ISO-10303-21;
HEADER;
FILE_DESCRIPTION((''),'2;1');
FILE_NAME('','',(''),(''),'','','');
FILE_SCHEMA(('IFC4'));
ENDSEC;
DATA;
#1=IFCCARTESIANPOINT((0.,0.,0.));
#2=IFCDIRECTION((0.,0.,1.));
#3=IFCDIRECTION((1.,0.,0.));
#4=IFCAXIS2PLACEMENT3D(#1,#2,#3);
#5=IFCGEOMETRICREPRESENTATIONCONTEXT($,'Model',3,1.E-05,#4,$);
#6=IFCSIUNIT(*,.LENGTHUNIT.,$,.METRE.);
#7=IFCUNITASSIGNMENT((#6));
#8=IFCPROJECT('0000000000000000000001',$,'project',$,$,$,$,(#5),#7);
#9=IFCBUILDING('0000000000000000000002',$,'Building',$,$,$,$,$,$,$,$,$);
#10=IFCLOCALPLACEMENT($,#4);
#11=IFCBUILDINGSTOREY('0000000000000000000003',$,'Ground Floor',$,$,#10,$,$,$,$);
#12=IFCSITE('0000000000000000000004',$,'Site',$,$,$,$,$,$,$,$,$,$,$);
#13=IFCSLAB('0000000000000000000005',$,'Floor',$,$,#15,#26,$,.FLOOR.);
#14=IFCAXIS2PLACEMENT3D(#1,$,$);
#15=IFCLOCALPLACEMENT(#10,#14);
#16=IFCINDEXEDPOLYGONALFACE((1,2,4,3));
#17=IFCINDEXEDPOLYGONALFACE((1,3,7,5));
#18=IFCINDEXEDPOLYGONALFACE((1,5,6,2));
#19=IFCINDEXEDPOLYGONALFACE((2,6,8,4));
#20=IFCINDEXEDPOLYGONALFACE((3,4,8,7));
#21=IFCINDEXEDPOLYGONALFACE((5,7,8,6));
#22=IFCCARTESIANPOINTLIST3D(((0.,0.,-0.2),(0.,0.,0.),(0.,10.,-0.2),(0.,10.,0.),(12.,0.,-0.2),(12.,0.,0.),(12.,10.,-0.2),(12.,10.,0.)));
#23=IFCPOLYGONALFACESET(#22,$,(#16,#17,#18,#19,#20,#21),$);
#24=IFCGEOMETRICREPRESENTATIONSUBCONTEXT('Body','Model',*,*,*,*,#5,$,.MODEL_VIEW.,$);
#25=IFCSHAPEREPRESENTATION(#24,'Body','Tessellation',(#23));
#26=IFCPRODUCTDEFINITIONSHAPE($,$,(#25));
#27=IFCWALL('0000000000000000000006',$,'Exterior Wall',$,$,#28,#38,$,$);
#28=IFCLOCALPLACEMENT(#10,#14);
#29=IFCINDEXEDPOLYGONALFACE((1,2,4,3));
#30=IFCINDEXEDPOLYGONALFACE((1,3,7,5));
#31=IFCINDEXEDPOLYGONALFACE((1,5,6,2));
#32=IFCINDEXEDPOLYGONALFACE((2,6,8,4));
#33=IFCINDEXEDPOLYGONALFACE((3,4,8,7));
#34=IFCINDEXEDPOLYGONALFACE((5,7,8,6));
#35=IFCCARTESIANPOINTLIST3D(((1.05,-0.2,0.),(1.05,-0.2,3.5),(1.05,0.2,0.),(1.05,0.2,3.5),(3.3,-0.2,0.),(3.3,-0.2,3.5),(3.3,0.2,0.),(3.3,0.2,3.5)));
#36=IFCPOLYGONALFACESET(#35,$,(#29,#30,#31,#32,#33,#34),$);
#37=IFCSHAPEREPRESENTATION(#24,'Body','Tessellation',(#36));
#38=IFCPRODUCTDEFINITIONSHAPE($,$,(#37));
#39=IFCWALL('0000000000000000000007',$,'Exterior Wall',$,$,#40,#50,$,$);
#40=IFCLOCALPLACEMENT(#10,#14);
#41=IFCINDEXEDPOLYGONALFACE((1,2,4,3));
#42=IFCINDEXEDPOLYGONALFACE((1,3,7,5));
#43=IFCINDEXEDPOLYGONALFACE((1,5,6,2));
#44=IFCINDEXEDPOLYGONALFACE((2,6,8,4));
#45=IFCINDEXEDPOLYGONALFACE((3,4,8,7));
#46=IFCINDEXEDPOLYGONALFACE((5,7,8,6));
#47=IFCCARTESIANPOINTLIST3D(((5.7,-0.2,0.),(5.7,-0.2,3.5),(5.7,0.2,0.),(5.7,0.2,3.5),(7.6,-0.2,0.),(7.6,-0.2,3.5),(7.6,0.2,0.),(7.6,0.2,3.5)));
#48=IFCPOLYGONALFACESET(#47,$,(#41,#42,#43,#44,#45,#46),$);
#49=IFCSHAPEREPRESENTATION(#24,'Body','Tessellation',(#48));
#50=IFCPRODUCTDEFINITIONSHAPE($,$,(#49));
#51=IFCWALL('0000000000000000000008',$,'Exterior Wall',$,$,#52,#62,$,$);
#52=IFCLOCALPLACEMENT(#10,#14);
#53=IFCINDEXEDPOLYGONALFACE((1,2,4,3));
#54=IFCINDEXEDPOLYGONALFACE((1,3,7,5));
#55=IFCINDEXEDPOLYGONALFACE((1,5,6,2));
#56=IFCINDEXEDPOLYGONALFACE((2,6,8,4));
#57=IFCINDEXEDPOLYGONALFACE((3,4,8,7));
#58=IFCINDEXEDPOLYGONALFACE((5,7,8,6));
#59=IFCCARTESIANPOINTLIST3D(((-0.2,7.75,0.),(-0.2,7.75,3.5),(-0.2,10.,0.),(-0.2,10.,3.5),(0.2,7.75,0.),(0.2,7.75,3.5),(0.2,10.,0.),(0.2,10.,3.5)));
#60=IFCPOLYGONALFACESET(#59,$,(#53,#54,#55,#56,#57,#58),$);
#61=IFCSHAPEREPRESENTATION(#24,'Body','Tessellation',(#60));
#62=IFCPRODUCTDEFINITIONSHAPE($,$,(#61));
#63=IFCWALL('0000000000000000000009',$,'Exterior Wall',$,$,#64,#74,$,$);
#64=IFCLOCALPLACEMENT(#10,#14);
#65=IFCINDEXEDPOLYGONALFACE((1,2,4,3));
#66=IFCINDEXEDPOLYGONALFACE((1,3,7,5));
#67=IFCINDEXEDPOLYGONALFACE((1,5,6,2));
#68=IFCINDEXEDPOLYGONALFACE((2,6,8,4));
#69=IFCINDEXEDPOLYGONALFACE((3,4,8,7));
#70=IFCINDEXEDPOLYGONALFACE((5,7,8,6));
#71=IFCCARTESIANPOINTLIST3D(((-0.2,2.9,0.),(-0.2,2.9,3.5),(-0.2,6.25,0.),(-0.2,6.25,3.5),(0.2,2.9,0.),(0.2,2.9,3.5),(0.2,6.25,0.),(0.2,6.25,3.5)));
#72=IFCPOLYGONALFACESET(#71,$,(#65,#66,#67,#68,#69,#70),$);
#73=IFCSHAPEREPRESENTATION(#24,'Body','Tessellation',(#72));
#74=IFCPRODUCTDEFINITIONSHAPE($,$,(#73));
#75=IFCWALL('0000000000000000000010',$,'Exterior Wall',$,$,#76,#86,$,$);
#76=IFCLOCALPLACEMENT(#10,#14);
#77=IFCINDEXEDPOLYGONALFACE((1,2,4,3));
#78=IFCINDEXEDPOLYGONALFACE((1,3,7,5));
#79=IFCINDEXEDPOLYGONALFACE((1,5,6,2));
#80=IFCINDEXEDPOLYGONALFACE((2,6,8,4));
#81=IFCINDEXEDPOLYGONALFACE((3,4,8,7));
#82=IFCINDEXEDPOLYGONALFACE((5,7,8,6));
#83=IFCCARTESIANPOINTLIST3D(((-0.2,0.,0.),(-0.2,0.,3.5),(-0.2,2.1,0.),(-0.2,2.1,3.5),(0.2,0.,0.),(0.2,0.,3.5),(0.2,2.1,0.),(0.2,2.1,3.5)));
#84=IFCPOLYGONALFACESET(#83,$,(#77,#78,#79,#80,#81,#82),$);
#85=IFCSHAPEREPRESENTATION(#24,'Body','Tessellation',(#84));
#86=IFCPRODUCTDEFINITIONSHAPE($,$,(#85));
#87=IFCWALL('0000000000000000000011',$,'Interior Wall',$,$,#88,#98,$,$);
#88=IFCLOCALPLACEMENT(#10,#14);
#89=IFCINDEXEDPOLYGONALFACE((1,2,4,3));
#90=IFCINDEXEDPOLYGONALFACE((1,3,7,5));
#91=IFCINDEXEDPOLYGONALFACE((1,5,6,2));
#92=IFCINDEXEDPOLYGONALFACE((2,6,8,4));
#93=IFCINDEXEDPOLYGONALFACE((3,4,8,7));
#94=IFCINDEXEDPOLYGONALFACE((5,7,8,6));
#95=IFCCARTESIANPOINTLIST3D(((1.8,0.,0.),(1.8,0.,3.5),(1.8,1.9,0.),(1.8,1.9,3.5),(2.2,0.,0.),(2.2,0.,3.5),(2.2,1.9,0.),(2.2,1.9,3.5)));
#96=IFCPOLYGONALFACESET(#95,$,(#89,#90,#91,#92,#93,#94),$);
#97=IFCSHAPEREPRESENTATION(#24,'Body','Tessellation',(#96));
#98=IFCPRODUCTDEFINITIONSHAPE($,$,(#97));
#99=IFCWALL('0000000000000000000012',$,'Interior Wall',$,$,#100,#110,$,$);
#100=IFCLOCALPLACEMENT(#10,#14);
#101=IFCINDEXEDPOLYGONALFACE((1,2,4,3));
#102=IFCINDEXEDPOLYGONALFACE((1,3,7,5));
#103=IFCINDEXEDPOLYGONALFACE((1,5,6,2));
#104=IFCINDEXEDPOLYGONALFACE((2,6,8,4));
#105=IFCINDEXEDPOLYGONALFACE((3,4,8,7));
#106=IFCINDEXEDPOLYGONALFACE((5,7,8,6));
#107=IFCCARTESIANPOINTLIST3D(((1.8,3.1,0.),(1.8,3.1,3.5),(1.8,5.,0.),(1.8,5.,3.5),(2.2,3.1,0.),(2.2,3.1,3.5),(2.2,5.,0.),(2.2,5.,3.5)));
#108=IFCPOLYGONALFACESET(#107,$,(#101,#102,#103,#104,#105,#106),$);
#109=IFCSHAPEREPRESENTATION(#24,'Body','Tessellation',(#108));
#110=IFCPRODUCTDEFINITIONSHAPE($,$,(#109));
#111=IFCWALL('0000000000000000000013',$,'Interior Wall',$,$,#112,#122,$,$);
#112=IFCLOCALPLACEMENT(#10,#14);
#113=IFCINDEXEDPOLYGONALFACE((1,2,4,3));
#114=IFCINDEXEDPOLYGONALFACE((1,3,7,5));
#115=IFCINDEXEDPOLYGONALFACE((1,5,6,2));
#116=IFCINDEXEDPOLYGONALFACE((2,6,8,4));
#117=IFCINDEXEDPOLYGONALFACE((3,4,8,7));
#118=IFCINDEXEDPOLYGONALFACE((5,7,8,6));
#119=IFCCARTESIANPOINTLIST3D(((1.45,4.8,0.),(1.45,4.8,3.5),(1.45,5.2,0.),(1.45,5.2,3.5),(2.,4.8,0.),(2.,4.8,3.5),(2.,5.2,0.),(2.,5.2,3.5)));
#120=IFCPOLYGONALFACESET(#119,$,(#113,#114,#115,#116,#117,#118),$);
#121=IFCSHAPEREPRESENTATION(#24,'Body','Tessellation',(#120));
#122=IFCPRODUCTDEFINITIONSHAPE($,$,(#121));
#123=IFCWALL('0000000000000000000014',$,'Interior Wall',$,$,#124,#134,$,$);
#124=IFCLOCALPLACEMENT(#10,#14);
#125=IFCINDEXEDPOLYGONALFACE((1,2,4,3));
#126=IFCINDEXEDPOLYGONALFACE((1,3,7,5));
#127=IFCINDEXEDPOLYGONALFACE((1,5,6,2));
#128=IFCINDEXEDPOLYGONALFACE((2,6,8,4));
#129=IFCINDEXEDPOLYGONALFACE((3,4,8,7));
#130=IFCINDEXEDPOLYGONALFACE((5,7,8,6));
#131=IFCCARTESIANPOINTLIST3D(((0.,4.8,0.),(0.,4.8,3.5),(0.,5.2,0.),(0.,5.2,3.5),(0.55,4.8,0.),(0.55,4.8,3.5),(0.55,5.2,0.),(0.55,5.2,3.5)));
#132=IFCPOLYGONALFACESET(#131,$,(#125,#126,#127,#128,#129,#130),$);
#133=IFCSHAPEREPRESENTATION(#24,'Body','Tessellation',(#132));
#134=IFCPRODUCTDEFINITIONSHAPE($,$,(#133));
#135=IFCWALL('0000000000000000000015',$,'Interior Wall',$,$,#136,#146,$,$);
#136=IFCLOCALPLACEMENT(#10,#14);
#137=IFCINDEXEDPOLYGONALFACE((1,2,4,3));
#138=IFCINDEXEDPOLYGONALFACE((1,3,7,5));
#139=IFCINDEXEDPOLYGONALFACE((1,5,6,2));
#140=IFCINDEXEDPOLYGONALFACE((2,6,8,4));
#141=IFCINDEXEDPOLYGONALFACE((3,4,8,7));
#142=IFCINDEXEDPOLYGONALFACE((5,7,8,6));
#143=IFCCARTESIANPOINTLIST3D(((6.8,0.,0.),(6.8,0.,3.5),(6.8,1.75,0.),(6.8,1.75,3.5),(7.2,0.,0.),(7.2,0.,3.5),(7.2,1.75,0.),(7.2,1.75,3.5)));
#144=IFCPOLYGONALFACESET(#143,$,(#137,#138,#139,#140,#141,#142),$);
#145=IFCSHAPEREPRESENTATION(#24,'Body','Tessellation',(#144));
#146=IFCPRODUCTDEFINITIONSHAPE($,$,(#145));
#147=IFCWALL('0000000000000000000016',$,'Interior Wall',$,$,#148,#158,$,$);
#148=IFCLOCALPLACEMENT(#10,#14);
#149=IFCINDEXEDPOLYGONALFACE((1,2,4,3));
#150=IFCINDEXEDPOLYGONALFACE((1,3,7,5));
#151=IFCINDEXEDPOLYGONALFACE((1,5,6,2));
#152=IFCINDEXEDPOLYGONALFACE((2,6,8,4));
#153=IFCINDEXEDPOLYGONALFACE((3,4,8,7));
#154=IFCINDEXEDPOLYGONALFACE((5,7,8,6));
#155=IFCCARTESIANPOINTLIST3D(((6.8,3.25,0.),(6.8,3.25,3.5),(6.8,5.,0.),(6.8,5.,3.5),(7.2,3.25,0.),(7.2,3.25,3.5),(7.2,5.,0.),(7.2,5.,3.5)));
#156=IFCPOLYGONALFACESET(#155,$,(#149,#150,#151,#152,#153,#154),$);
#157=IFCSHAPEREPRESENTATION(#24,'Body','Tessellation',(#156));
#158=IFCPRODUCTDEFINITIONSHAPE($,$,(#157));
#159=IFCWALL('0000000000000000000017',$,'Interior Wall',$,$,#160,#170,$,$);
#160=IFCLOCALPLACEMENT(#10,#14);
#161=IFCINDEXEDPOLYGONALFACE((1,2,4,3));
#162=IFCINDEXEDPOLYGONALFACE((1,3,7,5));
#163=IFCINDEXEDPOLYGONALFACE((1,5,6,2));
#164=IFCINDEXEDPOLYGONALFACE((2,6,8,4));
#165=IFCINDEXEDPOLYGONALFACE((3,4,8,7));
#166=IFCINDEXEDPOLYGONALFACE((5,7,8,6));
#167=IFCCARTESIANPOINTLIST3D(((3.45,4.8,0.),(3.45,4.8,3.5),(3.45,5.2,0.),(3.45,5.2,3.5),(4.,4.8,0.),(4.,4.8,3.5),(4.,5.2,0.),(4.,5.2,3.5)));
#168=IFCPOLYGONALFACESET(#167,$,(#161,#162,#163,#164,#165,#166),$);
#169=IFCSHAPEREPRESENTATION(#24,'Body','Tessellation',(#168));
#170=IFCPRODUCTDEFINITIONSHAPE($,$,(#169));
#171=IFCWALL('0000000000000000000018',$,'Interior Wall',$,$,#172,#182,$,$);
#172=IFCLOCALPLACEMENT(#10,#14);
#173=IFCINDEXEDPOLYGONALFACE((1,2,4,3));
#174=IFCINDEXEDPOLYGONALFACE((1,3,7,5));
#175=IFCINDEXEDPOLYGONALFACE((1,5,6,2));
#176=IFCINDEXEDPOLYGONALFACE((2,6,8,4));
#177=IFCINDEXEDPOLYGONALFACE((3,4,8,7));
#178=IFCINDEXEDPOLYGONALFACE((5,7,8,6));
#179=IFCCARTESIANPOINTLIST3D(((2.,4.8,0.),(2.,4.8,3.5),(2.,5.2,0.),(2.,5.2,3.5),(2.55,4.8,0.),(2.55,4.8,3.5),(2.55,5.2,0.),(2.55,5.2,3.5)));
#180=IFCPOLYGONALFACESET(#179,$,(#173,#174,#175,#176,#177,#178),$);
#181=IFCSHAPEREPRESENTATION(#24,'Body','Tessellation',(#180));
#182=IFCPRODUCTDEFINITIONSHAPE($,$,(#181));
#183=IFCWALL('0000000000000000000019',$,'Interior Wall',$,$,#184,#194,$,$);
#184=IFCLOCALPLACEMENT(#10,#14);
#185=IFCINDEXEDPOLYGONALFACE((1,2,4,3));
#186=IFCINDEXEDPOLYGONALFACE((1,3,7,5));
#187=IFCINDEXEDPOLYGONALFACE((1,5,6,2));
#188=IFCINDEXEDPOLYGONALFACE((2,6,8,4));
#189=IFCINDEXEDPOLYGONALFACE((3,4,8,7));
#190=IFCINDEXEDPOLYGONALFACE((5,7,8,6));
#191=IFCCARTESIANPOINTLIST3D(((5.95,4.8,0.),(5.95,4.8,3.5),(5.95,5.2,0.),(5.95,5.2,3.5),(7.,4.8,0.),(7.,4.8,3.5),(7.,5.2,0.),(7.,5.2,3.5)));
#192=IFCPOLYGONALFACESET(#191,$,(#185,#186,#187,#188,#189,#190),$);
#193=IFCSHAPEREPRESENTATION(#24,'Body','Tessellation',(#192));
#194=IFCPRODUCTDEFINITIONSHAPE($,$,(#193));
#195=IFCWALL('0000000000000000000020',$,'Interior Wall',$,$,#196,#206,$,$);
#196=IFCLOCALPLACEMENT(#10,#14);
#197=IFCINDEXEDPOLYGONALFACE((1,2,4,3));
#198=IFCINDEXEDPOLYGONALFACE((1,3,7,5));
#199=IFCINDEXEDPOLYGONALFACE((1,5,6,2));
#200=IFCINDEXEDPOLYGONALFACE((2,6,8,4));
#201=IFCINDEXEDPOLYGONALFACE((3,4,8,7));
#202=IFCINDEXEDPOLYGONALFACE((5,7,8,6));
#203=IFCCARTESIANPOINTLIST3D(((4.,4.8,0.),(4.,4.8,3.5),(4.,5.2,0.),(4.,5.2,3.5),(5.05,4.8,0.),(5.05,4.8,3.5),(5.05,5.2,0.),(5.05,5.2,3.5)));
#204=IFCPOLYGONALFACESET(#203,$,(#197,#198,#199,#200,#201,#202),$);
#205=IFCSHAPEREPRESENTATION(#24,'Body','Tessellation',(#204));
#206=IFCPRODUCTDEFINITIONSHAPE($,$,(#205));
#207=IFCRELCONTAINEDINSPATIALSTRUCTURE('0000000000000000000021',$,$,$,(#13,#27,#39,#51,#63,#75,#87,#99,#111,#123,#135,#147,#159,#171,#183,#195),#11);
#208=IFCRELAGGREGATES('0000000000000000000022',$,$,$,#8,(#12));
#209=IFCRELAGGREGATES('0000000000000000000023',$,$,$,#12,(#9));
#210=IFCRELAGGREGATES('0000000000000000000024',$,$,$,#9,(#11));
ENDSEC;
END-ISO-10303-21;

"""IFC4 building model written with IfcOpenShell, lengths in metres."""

from ifc_helpers import new_model, si_unit, frame, origin_with_axes, place, context, subcontext, project, spatial, indexed_curve, outline, extrude, element, save


model = new_model("IFC4")

# Units and contexts
model_context = context("Model", 3, precision=1e-05, world=origin_with_axes())
body_context = subcontext(model_context, "Body", "Model", "MODEL_VIEW")
ifc_project = project(units=[si_unit("LENGTHUNIT", "METRE")], contexts=[model_context])

# Site, building, storey
site = spatial("IfcSite", under=ifc_project, Name="Site")
building = spatial("IfcBuilding", under=site, Name="Building")
storey_placement = place(None, origin_with_axes())
storey = spatial("IfcBuildingStorey", under=building, at=storey_placement, Name="Ground Floor")

# Slab
slab_placement = place(storey_placement, frame((0.0, 0.0, -0.2), z_axis=(0.0, 0.0, 1.0), x_axis=(1.0, 0.0, 0.0)))
element("IfcSlab", 1, at=slab_placement, inside=storey, Name="Floor", PredefinedType="FLOOR", context=body_context, shape_type="SweptSolid", body=[
    extrude(outline(indexed_curve([(0.0, 0.0), (12.0, 0.0), (12.0, 10.0), (0.0, 10.0)])), None, (0.0, 0.0, 1.0), 0.2),
])

# Walls
wall_1_placement = place(storey_placement, frame((1.05, 0.0, 0.0), z_axis=(0.0, 0.0, 1.0), x_axis=(1.0, 0.0, 0.0)))
element("IfcWall", 2, at=wall_1_placement, inside=storey, Name="Exterior Wall", context=body_context, shape_type="SweptSolid", body=[
    extrude(outline(indexed_curve([(0.0, 0.0), (0.0, 0.4), (2.25, 0.4), (2.25, 0.0), (0.0, 0.0)], self_intersect=False)), frame((0.0, -0.2, 0.0), z_axis=(0.0, 0.0, 1.0), x_axis=(1.0, 0.0, 0.0)), (0.0, 0.0, 1.0), 3.5),
])
wall_2_placement = place(storey_placement, frame((5.7, 0.0, 0.0), z_axis=(0.0, 0.0, 1.0), x_axis=(1.0, 0.0, 0.0)))
element("IfcWall", 3, at=wall_2_placement, inside=storey, Name="Exterior Wall", context=body_context, shape_type="SweptSolid", body=[
    extrude(outline(indexed_curve([(0.0, 0.0), (0.0, 0.4), (1.9, 0.4), (1.9, 0.0), (0.0, 0.0)], self_intersect=False)), frame((0.0, -0.2, 0.0), z_axis=(0.0, 0.0, 1.0), x_axis=(1.0, 0.0, 0.0)), (0.0, 0.0, 1.0), 3.5),
])
wall_3_placement = place(storey_placement, frame((0.0, 10.0, 0.0), z_axis=(0.0, 0.0, 1.0), x_axis=(0.0, -1.0, 0.0)))
element("IfcWall", 4, at=wall_3_placement, inside=storey, Name="Exterior Wall", context=body_context, shape_type="SweptSolid", body=[
    extrude(outline(indexed_curve([(0.0, 0.0), (0.0, 0.4), (2.25, 0.4), (2.25, 0.0), (0.0, 0.0)], self_intersect=False)), frame((0.0, -0.2, 0.0), z_axis=(0.0, 0.0, 1.0), x_axis=(1.0, 0.0, 0.0)), (0.0, 0.0, 1.0), 3.5),
])
wall_4_placement = place(storey_placement, frame((0.0, 6.25, 0.0), z_axis=(0.0, 0.0, 1.0), x_axis=(0.0, -1.0, 0.0)))
element("IfcWall", 5, at=wall_4_placement, inside=storey, Name="Exterior Wall", context=body_context, shape_type="SweptSolid", body=[
    extrude(outline(indexed_curve([(0.0, 0.0), (0.0, 0.4), (3.35, 0.4), (3.35, 0.0), (0.0, 0.0)], self_intersect=False)), frame((0.0, -0.2, 0.0), z_axis=(0.0, 0.0, 1.0), x_axis=(1.0, 0.0, 0.0)), (0.0, 0.0, 1.0), 3.5),
])
wall_5_placement = place(storey_placement, frame((0.0, 2.1, 0.0), z_axis=(0.0, 0.0, 1.0), x_axis=(0.0, -1.0, 0.0)))
element("IfcWall", 6, at=wall_5_placement, inside=storey, Name="Exterior Wall", context=body_context, shape_type="SweptSolid", body=[
    extrude(outline(indexed_curve([(0.0, 0.0), (0.0, 0.4), (2.1, 0.4), (2.1, 0.0), (0.0, 0.0)], self_intersect=False)), frame((0.0, -0.2, 0.0), z_axis=(0.0, 0.0, 1.0), x_axis=(1.0, 0.0, 0.0)), (0.0, 0.0, 1.0), 3.5),
])
for number, where, z_axis, x_axis, name in (
    (7, (2.0, 0.0, 0.0), (0.0, 0.0, 1.0), (0.0, 1.0, 0.0), "Interior Wall"),
    (8, (2.0, 3.1, 0.0), (0.0, 0.0, 1.0), (0.0, 1.0, 0.0), "Interior Wall"),
):
    element("IfcWall", number, at=place(storey_placement, frame(where, z_axis=z_axis, x_axis=x_axis)), inside=storey, Name=name, context=body_context, shape_type="SweptSolid", body=[
        extrude(outline(indexed_curve([(0.0, 0.0), (0.0, 0.4), (1.9, 0.4), (1.9, 0.0), (0.0, 0.0)], self_intersect=False)), frame((0.0, -0.2, 0.0), z_axis=(0.0, 0.0, 1.0), x_axis=(1.0, 0.0, 0.0)), (0.0, 0.0, 1.0), 3.5),
    ])
for number, where, z_axis, x_axis, name in (
    (9, (2.0, 5.0, 0.0), (0.0, 0.0, 1.0), (-1.0, 0.0, 0.0), "Interior Wall"),
    (10, (0.55, 5.0, 0.0), (0.0, 0.0, 1.0), (-1.0, 0.0, 0.0), "Interior Wall"),
):
    element("IfcWall", number, at=place(storey_placement, frame(where, z_axis=z_axis, x_axis=x_axis)), inside=storey, Name=name, context=body_context, shape_type="SweptSolid", body=[
        extrude(outline(indexed_curve([(0.0, 0.0), (0.0, 0.4), (0.55, 0.4), (0.55, 0.0), (0.0, 0.0)], self_intersect=False)), frame((0.0, -0.2, 0.0), z_axis=(0.0, 0.0, 1.0), x_axis=(1.0, 0.0, 0.0)), (0.0, 0.0, 1.0), 3.5),
    ])
for number, where, z_axis, x_axis, name in (
    (11, (7.0, 0.0, 0.0), (0.0, 0.0, 1.0), (0.0, 1.0, 0.0), "Interior Wall"),
    (12, (7.0, 3.25, 0.0), (0.0, 0.0, 1.0), (0.0, 1.0, 0.0), "Interior Wall"),
):
    element("IfcWall", number, at=place(storey_placement, frame(where, z_axis=z_axis, x_axis=x_axis)), inside=storey, Name=name, context=body_context, shape_type="SweptSolid", body=[
        extrude(outline(indexed_curve([(0.0, 0.0), (0.0, 0.4), (1.75, 0.4), (1.75, 0.0), (0.0, 0.0)], self_intersect=False)), frame((0.0, -0.2, 0.0), z_axis=(0.0, 0.0, 1.0), x_axis=(1.0, 0.0, 0.0)), (0.0, 0.0, 1.0), 3.5),
    ])
for number, where, z_axis, x_axis, name in (
    (13, (4.0, 5.0, 0.0), (0.0, 0.0, 1.0), (-1.0, 0.0, 0.0), "Interior Wall"),
    (14, (2.55, 5.0, 0.0), (0.0, 0.0, 1.0), (-1.0, 0.0, 0.0), "Interior Wall"),
):
    element("IfcWall", number, at=place(storey_placement, frame(where, z_axis=z_axis, x_axis=x_axis)), inside=storey, Name=name, context=body_context, shape_type="SweptSolid", body=[
        extrude(outline(indexed_curve([(0.0, 0.0), (0.0, 0.4), (0.55, 0.4), (0.55, 0.0), (0.0, 0.0)], self_intersect=False)), frame((0.0, -0.2, 0.0), z_axis=(0.0, 0.0, 1.0), x_axis=(1.0, 0.0, 0.0)), (0.0, 0.0, 1.0), 3.5),
    ])
for number, where, z_axis, x_axis, name in (
    (15, (7.0, 5.0, 0.0), (0.0, 0.0, 1.0), (-1.0, 0.0, 0.0), "Interior Wall"),
    (16, (5.05, 5.0, 0.0), (0.0, 0.0, 1.0), (-1.0, 0.0, 0.0), "Interior Wall"),
):
    element("IfcWall", number, at=place(storey_placement, frame(where, z_axis=z_axis, x_axis=x_axis)), inside=storey, Name=name, context=body_context, shape_type="SweptSolid", body=[
        extrude(outline(indexed_curve([(0.0, 0.0), (0.0, 0.4), (1.05, 0.4), (1.05, 0.0), (0.0, 0.0)], self_intersect=False)), frame((0.0, -0.2, 0.0), z_axis=(0.0, 0.0, 1.0), x_axis=(1.0, 0.0, 0.0)), (0.0, 0.0, 1.0), 3.5),
    ])

save(model, "model.ifc")
